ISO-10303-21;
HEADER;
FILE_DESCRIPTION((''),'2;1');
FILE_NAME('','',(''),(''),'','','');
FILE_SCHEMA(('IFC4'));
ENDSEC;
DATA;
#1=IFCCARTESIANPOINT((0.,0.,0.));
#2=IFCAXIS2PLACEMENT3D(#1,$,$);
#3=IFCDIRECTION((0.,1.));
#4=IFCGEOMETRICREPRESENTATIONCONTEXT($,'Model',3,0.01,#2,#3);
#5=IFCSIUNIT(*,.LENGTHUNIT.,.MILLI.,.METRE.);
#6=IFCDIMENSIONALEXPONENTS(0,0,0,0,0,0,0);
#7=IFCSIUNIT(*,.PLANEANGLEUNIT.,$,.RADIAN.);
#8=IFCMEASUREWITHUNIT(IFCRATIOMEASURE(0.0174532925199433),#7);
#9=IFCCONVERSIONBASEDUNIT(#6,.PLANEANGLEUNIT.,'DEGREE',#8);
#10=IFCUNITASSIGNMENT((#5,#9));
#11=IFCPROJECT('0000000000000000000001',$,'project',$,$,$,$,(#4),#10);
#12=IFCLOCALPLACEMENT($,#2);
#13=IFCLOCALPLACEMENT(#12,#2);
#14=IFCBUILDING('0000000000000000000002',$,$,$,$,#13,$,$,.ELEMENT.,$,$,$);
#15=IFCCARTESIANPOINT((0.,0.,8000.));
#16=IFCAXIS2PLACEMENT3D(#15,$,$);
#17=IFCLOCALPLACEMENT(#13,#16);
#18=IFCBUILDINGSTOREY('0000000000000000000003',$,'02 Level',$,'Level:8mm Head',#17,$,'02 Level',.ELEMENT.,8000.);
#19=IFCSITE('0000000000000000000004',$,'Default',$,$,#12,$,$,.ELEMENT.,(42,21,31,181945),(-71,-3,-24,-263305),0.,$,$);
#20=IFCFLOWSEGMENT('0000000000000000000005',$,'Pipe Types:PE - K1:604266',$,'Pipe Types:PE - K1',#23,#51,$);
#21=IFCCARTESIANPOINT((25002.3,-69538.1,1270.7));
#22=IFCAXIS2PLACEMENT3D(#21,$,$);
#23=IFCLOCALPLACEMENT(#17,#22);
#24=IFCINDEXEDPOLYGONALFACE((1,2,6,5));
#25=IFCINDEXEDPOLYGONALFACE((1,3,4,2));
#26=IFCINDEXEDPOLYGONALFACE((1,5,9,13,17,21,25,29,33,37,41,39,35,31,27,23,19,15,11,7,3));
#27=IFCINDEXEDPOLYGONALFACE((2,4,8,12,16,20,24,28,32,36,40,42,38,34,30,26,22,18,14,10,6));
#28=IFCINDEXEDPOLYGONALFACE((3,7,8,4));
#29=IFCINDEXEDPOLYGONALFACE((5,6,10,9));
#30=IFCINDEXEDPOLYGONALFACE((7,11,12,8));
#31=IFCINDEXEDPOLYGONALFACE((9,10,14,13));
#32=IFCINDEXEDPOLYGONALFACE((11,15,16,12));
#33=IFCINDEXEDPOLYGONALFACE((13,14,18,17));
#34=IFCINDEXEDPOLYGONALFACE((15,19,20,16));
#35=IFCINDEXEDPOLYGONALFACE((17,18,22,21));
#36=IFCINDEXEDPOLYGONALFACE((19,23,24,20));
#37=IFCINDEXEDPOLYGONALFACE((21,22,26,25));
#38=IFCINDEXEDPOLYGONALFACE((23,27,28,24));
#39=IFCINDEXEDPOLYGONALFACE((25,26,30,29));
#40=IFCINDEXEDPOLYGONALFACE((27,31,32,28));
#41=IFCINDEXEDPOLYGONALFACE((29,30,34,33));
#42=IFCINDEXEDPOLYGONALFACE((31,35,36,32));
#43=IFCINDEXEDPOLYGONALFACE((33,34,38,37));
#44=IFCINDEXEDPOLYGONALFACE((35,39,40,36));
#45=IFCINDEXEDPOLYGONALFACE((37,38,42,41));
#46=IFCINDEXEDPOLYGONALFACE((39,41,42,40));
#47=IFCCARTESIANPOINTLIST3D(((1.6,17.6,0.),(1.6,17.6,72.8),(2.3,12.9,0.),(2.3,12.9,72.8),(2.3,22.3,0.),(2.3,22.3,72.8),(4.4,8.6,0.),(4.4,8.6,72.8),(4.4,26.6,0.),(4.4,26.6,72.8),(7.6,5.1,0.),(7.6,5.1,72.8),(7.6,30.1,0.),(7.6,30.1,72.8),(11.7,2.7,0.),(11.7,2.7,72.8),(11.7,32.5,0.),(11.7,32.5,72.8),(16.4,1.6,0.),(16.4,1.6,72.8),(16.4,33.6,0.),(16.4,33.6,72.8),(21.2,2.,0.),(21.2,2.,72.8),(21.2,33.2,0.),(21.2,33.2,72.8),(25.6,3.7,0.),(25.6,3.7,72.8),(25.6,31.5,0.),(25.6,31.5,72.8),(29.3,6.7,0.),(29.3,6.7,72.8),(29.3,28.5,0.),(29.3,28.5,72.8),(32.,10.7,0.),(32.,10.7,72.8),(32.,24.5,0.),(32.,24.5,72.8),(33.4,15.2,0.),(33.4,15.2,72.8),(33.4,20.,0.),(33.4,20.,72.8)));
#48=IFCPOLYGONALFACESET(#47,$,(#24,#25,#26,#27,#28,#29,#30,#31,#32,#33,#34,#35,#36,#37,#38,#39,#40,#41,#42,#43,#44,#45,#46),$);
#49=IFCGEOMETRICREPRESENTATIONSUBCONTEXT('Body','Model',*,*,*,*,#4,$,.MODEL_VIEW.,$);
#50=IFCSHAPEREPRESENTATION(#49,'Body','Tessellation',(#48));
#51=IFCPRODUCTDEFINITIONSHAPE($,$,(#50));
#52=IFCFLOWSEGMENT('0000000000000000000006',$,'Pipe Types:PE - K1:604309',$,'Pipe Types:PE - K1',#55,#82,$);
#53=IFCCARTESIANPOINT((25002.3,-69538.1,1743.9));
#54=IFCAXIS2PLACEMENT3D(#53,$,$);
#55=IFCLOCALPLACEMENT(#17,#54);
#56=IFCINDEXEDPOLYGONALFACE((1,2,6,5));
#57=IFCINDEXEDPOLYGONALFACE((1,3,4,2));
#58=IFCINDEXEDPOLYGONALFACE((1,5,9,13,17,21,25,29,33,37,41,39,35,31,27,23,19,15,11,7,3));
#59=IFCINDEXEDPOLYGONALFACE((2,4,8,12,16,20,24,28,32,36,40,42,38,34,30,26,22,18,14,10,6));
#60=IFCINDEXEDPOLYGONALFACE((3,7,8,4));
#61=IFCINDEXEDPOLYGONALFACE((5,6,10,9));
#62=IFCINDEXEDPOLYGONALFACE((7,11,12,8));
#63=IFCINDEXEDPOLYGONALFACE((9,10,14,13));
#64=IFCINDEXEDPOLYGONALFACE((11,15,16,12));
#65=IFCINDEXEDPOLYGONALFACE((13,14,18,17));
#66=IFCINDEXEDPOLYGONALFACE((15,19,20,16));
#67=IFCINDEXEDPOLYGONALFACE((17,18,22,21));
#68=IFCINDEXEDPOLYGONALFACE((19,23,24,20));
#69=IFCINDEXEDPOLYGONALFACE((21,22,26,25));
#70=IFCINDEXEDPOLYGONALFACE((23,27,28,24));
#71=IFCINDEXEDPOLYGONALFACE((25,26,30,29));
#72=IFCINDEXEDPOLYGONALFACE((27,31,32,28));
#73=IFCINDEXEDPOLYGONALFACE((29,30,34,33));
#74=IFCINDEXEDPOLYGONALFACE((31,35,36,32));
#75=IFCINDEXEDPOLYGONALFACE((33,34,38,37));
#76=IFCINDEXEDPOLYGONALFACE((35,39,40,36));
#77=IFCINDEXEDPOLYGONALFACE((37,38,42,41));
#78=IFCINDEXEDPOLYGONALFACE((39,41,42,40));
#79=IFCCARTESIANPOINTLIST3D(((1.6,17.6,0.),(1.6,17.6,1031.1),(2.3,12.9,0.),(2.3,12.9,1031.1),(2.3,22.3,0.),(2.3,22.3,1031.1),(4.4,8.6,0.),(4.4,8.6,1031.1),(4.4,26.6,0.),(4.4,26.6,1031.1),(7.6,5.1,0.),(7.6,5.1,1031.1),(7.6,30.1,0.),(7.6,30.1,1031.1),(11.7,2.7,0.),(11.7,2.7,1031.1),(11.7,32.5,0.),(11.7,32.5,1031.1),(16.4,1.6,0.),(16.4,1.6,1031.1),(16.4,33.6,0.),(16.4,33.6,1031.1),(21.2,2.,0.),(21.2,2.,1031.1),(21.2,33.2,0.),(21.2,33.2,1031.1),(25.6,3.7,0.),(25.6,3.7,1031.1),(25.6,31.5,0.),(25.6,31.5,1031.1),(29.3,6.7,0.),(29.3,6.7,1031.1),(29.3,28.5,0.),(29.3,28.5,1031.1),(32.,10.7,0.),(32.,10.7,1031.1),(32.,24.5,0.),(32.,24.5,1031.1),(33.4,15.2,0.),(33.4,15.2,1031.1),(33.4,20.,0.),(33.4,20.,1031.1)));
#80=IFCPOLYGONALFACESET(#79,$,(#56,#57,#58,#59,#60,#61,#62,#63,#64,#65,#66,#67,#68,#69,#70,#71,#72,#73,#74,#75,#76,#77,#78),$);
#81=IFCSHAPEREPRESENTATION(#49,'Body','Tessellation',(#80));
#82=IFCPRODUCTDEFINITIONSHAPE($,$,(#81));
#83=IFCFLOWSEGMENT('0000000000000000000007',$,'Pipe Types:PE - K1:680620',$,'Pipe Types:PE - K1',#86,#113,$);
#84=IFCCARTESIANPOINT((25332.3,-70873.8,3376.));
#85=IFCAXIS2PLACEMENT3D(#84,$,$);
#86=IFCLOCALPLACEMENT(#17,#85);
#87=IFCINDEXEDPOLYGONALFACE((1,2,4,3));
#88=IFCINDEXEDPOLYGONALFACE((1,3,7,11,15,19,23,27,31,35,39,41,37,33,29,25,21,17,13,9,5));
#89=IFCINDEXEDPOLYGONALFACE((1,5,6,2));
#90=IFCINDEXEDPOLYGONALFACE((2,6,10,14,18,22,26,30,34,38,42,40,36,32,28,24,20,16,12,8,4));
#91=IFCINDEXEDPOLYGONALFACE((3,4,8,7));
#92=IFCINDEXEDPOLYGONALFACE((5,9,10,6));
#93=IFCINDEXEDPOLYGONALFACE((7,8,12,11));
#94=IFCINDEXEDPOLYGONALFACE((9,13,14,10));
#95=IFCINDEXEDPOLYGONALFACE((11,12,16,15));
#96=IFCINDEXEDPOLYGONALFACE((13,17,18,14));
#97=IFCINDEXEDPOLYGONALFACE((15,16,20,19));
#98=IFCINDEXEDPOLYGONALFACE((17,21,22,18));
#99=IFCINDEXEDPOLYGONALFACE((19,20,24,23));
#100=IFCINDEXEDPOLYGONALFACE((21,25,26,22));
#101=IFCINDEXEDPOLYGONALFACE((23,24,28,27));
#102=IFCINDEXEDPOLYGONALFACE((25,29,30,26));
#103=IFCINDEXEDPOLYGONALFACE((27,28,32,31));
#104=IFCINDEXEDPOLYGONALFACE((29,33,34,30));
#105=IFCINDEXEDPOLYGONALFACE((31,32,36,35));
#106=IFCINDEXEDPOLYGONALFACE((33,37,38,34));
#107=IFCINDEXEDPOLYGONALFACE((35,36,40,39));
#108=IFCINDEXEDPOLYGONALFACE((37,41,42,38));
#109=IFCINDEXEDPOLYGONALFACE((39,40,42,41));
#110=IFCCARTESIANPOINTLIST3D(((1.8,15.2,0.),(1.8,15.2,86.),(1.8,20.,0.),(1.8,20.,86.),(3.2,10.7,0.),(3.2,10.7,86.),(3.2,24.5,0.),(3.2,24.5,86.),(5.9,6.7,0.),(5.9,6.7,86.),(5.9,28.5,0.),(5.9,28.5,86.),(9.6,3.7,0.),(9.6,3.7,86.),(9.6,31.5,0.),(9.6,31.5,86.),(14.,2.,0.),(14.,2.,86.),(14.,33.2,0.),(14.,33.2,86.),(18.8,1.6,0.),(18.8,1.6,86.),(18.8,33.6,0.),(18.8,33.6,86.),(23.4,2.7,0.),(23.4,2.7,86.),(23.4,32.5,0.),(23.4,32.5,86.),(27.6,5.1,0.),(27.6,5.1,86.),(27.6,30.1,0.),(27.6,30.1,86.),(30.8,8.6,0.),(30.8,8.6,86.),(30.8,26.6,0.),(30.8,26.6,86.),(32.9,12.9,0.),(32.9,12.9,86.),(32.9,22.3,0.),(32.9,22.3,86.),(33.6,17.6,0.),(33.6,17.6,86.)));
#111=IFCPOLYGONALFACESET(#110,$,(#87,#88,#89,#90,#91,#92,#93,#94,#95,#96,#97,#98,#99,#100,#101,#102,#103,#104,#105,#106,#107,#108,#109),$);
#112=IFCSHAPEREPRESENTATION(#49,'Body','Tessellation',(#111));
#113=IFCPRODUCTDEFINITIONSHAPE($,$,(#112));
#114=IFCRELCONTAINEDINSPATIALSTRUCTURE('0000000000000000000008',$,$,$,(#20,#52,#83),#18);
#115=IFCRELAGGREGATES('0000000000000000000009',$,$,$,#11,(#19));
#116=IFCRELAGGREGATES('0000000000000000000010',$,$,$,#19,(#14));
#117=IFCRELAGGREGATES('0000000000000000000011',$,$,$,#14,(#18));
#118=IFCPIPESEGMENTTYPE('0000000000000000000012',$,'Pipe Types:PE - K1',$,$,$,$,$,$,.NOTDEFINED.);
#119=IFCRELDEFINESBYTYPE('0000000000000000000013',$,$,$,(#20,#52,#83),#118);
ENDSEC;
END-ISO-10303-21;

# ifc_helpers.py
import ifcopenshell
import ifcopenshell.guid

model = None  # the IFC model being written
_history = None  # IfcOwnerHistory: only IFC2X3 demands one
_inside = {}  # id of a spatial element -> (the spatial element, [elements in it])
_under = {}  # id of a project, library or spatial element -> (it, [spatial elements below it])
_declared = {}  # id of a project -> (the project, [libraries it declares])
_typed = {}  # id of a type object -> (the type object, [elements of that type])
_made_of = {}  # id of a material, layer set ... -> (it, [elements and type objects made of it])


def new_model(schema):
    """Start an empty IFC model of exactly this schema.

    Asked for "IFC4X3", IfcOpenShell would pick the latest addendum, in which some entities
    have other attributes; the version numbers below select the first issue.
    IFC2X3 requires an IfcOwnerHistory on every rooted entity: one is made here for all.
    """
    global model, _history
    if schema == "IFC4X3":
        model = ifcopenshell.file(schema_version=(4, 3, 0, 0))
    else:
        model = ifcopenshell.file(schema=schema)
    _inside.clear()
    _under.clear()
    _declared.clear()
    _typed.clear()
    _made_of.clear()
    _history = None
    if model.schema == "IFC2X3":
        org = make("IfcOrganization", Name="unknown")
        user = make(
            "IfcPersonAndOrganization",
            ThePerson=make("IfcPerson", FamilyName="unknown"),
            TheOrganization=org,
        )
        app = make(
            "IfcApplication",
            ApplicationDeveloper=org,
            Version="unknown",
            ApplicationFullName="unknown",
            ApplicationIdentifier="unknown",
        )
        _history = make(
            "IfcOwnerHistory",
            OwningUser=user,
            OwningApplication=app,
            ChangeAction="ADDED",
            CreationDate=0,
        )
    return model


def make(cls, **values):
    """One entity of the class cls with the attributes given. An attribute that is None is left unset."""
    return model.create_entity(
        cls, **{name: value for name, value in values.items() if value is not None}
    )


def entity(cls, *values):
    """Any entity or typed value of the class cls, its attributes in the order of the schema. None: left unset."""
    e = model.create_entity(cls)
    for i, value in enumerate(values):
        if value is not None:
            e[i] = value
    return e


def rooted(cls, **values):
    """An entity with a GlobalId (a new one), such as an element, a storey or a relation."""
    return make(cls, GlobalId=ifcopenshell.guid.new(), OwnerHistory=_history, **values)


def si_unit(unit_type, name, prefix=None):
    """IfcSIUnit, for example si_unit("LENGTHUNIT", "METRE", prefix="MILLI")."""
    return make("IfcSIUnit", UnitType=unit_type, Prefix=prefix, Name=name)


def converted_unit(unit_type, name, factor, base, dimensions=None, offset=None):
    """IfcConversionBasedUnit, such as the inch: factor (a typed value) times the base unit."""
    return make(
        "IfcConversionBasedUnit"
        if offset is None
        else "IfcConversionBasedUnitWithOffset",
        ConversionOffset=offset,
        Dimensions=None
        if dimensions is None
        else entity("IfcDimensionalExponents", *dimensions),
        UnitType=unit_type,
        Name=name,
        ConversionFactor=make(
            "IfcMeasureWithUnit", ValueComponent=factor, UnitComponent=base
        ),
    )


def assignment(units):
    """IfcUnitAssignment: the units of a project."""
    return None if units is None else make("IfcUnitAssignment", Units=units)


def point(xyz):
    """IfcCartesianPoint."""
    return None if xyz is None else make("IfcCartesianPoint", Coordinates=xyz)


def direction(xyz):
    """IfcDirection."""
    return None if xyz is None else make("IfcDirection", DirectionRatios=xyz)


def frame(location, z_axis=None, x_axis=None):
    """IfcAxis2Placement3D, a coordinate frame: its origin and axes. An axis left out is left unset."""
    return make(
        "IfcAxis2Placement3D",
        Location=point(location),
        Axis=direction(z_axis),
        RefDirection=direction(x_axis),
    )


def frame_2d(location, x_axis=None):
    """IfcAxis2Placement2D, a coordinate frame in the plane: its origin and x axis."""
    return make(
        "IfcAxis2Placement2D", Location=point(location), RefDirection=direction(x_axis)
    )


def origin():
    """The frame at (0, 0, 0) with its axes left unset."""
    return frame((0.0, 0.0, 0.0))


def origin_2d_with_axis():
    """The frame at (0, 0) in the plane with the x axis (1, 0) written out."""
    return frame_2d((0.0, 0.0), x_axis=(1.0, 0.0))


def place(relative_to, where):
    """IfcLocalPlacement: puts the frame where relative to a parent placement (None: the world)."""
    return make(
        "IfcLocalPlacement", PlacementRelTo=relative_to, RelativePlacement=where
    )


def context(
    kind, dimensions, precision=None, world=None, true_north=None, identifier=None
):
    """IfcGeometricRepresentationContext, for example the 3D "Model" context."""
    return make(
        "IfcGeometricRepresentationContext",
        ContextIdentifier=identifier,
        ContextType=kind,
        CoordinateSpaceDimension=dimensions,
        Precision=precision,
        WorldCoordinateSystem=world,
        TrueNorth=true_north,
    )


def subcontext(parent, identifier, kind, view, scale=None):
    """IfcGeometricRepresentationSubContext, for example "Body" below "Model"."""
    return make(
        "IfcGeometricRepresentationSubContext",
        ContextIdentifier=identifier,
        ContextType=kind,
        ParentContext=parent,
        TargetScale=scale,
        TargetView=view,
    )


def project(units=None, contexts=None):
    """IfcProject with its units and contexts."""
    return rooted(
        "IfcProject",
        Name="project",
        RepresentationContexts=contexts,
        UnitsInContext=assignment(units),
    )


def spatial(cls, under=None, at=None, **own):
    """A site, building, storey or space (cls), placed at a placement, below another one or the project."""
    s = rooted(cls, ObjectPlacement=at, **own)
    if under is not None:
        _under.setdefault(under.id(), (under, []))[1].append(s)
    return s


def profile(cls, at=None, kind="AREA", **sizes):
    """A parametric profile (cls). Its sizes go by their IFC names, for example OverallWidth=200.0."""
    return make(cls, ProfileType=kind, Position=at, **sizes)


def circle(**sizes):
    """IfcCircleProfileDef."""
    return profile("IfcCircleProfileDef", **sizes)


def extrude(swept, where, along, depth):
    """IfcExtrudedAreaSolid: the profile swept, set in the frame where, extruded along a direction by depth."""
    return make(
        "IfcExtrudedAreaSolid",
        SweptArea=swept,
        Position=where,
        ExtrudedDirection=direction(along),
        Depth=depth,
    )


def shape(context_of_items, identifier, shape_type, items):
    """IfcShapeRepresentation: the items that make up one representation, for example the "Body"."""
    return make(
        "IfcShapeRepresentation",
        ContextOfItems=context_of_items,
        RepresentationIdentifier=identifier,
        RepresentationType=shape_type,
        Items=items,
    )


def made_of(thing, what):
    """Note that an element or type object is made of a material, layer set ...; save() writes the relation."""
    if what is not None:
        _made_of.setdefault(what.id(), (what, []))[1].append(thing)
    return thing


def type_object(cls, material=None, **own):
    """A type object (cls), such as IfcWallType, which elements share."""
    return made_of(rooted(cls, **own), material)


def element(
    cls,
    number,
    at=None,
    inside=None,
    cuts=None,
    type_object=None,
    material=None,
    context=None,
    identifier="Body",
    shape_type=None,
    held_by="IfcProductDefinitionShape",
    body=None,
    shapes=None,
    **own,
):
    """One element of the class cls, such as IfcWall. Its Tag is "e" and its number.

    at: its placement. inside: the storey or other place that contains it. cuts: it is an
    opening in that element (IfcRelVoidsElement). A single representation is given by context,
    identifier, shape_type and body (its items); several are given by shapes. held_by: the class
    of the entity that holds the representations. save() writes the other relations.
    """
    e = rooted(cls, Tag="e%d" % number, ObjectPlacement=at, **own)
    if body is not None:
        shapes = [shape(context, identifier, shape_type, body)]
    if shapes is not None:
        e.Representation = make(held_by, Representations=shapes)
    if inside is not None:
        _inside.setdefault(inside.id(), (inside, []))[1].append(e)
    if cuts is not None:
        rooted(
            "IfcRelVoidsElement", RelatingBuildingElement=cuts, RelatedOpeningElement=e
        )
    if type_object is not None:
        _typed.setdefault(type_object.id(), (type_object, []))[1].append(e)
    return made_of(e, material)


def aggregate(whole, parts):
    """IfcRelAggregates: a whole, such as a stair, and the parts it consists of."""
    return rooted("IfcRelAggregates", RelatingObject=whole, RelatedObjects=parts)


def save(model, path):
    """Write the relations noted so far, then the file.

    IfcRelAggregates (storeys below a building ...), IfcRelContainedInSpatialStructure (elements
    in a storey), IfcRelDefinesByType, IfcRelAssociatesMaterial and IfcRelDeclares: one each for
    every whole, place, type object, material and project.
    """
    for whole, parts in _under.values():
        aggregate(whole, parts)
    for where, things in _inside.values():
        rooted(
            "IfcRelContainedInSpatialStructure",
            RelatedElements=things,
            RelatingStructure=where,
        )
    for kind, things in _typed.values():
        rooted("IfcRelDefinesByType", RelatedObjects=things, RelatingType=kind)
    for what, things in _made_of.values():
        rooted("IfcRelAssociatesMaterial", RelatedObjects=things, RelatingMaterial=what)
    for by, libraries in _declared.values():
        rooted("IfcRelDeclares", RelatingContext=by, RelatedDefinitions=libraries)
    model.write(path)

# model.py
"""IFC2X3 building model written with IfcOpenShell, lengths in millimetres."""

from ifc_helpers import new_model, entity, si_unit, converted_unit, direction, frame, origin, origin_2d_with_axis, place, context, subcontext, project, spatial, circle, extrude, type_object, element, save


model = new_model("IFC2X3")

# Units and contexts
model_context = context("Model", 3, precision=0.01, world=origin(), true_north=direction((0.0, 1.0)))
body_context = subcontext(model_context, "Body", "Model", "MODEL_VIEW")
ifc_project = project(units=[si_unit("LENGTHUNIT", "METRE", prefix="MILLI"), converted_unit("PLANEANGLEUNIT", "DEGREE", entity("IfcRatioMeasure", 0.0174532925199433), si_unit("PLANEANGLEUNIT", "RADIAN"), dimensions=[0, 0, 0, 0, 0, 0, 0])], contexts=[model_context])

# Site, building, storey
site_placement = place(None, origin())
site = spatial("IfcSite", under=ifc_project, at=site_placement, Name="Default", CompositionType="ELEMENT", RefLatitude=(42, 21, 31, 181945), RefLongitude=(-71, -3, -24, -263305), RefElevation=0.0)
building_placement = place(site_placement, origin())
building = spatial("IfcBuilding", under=site, at=building_placement, CompositionType="ELEMENT")
storey_placement = place(building_placement, frame((0.0, 0.0, 8000.0)))
storey = spatial("IfcBuildingStorey", under=building, at=storey_placement, Name="02 Level", ObjectType="Level:8mm Head", LongName="02 Level", CompositionType="ELEMENT", Elevation=8000.0)

# Flow segments
pipe_segment_type = type_object("IfcPipeSegmentType", Name="Pipe Types:PE - K1", PredefinedType="NOTDEFINED")
flow_segment_1_placement = place(storey_placement, frame((25002.3, -69538.1, 1270.7)))
element("IfcFlowSegment", 1, at=flow_segment_1_placement, inside=storey, type_object=pipe_segment_type, Name="Pipe Types:PE - K1:604266", ObjectType="Pipe Types:PE - K1", context=body_context, shape_type="SweptSolid", body=[
    extrude(circle(Radius=16.0, at=origin_2d_with_axis()), frame((17.6, 17.6, 0.0), z_axis=(0.0, 0.0, 1.0), x_axis=(-1.0, 0.0, 0.0)), (0.0, 0.0, 1.0), 72.8),
])
flow_segment_2_placement = place(storey_placement, frame((25002.3, -69538.1, 1743.9)))
element("IfcFlowSegment", 2, at=flow_segment_2_placement, inside=storey, type_object=pipe_segment_type, Name="Pipe Types:PE - K1:604309", ObjectType="Pipe Types:PE - K1", context=body_context, shape_type="SweptSolid", body=[
    extrude(circle(Radius=16.0, at=origin_2d_with_axis()), frame((17.6, 17.6, 0.0), z_axis=(0.0, 0.0, 1.0), x_axis=(-1.0, 0.0, 0.0)), (0.0, 0.0, 1.0), 1031.1),
])
flow_segment_3_placement = place(storey_placement, frame((25332.3, -70873.8, 3376.0)))
element("IfcFlowSegment", 3, at=flow_segment_3_placement, inside=storey, type_object=pipe_segment_type, Name="Pipe Types:PE - K1:680620", ObjectType="Pipe Types:PE - K1", context=body_context, shape_type="SweptSolid", body=[
    extrude(circle(Radius=16.0, at=origin_2d_with_axis()), frame((17.6, 17.6, 0.0)), (0.0, 0.0, 1.0), 86.0),
])

save(model, "model.ifc")
